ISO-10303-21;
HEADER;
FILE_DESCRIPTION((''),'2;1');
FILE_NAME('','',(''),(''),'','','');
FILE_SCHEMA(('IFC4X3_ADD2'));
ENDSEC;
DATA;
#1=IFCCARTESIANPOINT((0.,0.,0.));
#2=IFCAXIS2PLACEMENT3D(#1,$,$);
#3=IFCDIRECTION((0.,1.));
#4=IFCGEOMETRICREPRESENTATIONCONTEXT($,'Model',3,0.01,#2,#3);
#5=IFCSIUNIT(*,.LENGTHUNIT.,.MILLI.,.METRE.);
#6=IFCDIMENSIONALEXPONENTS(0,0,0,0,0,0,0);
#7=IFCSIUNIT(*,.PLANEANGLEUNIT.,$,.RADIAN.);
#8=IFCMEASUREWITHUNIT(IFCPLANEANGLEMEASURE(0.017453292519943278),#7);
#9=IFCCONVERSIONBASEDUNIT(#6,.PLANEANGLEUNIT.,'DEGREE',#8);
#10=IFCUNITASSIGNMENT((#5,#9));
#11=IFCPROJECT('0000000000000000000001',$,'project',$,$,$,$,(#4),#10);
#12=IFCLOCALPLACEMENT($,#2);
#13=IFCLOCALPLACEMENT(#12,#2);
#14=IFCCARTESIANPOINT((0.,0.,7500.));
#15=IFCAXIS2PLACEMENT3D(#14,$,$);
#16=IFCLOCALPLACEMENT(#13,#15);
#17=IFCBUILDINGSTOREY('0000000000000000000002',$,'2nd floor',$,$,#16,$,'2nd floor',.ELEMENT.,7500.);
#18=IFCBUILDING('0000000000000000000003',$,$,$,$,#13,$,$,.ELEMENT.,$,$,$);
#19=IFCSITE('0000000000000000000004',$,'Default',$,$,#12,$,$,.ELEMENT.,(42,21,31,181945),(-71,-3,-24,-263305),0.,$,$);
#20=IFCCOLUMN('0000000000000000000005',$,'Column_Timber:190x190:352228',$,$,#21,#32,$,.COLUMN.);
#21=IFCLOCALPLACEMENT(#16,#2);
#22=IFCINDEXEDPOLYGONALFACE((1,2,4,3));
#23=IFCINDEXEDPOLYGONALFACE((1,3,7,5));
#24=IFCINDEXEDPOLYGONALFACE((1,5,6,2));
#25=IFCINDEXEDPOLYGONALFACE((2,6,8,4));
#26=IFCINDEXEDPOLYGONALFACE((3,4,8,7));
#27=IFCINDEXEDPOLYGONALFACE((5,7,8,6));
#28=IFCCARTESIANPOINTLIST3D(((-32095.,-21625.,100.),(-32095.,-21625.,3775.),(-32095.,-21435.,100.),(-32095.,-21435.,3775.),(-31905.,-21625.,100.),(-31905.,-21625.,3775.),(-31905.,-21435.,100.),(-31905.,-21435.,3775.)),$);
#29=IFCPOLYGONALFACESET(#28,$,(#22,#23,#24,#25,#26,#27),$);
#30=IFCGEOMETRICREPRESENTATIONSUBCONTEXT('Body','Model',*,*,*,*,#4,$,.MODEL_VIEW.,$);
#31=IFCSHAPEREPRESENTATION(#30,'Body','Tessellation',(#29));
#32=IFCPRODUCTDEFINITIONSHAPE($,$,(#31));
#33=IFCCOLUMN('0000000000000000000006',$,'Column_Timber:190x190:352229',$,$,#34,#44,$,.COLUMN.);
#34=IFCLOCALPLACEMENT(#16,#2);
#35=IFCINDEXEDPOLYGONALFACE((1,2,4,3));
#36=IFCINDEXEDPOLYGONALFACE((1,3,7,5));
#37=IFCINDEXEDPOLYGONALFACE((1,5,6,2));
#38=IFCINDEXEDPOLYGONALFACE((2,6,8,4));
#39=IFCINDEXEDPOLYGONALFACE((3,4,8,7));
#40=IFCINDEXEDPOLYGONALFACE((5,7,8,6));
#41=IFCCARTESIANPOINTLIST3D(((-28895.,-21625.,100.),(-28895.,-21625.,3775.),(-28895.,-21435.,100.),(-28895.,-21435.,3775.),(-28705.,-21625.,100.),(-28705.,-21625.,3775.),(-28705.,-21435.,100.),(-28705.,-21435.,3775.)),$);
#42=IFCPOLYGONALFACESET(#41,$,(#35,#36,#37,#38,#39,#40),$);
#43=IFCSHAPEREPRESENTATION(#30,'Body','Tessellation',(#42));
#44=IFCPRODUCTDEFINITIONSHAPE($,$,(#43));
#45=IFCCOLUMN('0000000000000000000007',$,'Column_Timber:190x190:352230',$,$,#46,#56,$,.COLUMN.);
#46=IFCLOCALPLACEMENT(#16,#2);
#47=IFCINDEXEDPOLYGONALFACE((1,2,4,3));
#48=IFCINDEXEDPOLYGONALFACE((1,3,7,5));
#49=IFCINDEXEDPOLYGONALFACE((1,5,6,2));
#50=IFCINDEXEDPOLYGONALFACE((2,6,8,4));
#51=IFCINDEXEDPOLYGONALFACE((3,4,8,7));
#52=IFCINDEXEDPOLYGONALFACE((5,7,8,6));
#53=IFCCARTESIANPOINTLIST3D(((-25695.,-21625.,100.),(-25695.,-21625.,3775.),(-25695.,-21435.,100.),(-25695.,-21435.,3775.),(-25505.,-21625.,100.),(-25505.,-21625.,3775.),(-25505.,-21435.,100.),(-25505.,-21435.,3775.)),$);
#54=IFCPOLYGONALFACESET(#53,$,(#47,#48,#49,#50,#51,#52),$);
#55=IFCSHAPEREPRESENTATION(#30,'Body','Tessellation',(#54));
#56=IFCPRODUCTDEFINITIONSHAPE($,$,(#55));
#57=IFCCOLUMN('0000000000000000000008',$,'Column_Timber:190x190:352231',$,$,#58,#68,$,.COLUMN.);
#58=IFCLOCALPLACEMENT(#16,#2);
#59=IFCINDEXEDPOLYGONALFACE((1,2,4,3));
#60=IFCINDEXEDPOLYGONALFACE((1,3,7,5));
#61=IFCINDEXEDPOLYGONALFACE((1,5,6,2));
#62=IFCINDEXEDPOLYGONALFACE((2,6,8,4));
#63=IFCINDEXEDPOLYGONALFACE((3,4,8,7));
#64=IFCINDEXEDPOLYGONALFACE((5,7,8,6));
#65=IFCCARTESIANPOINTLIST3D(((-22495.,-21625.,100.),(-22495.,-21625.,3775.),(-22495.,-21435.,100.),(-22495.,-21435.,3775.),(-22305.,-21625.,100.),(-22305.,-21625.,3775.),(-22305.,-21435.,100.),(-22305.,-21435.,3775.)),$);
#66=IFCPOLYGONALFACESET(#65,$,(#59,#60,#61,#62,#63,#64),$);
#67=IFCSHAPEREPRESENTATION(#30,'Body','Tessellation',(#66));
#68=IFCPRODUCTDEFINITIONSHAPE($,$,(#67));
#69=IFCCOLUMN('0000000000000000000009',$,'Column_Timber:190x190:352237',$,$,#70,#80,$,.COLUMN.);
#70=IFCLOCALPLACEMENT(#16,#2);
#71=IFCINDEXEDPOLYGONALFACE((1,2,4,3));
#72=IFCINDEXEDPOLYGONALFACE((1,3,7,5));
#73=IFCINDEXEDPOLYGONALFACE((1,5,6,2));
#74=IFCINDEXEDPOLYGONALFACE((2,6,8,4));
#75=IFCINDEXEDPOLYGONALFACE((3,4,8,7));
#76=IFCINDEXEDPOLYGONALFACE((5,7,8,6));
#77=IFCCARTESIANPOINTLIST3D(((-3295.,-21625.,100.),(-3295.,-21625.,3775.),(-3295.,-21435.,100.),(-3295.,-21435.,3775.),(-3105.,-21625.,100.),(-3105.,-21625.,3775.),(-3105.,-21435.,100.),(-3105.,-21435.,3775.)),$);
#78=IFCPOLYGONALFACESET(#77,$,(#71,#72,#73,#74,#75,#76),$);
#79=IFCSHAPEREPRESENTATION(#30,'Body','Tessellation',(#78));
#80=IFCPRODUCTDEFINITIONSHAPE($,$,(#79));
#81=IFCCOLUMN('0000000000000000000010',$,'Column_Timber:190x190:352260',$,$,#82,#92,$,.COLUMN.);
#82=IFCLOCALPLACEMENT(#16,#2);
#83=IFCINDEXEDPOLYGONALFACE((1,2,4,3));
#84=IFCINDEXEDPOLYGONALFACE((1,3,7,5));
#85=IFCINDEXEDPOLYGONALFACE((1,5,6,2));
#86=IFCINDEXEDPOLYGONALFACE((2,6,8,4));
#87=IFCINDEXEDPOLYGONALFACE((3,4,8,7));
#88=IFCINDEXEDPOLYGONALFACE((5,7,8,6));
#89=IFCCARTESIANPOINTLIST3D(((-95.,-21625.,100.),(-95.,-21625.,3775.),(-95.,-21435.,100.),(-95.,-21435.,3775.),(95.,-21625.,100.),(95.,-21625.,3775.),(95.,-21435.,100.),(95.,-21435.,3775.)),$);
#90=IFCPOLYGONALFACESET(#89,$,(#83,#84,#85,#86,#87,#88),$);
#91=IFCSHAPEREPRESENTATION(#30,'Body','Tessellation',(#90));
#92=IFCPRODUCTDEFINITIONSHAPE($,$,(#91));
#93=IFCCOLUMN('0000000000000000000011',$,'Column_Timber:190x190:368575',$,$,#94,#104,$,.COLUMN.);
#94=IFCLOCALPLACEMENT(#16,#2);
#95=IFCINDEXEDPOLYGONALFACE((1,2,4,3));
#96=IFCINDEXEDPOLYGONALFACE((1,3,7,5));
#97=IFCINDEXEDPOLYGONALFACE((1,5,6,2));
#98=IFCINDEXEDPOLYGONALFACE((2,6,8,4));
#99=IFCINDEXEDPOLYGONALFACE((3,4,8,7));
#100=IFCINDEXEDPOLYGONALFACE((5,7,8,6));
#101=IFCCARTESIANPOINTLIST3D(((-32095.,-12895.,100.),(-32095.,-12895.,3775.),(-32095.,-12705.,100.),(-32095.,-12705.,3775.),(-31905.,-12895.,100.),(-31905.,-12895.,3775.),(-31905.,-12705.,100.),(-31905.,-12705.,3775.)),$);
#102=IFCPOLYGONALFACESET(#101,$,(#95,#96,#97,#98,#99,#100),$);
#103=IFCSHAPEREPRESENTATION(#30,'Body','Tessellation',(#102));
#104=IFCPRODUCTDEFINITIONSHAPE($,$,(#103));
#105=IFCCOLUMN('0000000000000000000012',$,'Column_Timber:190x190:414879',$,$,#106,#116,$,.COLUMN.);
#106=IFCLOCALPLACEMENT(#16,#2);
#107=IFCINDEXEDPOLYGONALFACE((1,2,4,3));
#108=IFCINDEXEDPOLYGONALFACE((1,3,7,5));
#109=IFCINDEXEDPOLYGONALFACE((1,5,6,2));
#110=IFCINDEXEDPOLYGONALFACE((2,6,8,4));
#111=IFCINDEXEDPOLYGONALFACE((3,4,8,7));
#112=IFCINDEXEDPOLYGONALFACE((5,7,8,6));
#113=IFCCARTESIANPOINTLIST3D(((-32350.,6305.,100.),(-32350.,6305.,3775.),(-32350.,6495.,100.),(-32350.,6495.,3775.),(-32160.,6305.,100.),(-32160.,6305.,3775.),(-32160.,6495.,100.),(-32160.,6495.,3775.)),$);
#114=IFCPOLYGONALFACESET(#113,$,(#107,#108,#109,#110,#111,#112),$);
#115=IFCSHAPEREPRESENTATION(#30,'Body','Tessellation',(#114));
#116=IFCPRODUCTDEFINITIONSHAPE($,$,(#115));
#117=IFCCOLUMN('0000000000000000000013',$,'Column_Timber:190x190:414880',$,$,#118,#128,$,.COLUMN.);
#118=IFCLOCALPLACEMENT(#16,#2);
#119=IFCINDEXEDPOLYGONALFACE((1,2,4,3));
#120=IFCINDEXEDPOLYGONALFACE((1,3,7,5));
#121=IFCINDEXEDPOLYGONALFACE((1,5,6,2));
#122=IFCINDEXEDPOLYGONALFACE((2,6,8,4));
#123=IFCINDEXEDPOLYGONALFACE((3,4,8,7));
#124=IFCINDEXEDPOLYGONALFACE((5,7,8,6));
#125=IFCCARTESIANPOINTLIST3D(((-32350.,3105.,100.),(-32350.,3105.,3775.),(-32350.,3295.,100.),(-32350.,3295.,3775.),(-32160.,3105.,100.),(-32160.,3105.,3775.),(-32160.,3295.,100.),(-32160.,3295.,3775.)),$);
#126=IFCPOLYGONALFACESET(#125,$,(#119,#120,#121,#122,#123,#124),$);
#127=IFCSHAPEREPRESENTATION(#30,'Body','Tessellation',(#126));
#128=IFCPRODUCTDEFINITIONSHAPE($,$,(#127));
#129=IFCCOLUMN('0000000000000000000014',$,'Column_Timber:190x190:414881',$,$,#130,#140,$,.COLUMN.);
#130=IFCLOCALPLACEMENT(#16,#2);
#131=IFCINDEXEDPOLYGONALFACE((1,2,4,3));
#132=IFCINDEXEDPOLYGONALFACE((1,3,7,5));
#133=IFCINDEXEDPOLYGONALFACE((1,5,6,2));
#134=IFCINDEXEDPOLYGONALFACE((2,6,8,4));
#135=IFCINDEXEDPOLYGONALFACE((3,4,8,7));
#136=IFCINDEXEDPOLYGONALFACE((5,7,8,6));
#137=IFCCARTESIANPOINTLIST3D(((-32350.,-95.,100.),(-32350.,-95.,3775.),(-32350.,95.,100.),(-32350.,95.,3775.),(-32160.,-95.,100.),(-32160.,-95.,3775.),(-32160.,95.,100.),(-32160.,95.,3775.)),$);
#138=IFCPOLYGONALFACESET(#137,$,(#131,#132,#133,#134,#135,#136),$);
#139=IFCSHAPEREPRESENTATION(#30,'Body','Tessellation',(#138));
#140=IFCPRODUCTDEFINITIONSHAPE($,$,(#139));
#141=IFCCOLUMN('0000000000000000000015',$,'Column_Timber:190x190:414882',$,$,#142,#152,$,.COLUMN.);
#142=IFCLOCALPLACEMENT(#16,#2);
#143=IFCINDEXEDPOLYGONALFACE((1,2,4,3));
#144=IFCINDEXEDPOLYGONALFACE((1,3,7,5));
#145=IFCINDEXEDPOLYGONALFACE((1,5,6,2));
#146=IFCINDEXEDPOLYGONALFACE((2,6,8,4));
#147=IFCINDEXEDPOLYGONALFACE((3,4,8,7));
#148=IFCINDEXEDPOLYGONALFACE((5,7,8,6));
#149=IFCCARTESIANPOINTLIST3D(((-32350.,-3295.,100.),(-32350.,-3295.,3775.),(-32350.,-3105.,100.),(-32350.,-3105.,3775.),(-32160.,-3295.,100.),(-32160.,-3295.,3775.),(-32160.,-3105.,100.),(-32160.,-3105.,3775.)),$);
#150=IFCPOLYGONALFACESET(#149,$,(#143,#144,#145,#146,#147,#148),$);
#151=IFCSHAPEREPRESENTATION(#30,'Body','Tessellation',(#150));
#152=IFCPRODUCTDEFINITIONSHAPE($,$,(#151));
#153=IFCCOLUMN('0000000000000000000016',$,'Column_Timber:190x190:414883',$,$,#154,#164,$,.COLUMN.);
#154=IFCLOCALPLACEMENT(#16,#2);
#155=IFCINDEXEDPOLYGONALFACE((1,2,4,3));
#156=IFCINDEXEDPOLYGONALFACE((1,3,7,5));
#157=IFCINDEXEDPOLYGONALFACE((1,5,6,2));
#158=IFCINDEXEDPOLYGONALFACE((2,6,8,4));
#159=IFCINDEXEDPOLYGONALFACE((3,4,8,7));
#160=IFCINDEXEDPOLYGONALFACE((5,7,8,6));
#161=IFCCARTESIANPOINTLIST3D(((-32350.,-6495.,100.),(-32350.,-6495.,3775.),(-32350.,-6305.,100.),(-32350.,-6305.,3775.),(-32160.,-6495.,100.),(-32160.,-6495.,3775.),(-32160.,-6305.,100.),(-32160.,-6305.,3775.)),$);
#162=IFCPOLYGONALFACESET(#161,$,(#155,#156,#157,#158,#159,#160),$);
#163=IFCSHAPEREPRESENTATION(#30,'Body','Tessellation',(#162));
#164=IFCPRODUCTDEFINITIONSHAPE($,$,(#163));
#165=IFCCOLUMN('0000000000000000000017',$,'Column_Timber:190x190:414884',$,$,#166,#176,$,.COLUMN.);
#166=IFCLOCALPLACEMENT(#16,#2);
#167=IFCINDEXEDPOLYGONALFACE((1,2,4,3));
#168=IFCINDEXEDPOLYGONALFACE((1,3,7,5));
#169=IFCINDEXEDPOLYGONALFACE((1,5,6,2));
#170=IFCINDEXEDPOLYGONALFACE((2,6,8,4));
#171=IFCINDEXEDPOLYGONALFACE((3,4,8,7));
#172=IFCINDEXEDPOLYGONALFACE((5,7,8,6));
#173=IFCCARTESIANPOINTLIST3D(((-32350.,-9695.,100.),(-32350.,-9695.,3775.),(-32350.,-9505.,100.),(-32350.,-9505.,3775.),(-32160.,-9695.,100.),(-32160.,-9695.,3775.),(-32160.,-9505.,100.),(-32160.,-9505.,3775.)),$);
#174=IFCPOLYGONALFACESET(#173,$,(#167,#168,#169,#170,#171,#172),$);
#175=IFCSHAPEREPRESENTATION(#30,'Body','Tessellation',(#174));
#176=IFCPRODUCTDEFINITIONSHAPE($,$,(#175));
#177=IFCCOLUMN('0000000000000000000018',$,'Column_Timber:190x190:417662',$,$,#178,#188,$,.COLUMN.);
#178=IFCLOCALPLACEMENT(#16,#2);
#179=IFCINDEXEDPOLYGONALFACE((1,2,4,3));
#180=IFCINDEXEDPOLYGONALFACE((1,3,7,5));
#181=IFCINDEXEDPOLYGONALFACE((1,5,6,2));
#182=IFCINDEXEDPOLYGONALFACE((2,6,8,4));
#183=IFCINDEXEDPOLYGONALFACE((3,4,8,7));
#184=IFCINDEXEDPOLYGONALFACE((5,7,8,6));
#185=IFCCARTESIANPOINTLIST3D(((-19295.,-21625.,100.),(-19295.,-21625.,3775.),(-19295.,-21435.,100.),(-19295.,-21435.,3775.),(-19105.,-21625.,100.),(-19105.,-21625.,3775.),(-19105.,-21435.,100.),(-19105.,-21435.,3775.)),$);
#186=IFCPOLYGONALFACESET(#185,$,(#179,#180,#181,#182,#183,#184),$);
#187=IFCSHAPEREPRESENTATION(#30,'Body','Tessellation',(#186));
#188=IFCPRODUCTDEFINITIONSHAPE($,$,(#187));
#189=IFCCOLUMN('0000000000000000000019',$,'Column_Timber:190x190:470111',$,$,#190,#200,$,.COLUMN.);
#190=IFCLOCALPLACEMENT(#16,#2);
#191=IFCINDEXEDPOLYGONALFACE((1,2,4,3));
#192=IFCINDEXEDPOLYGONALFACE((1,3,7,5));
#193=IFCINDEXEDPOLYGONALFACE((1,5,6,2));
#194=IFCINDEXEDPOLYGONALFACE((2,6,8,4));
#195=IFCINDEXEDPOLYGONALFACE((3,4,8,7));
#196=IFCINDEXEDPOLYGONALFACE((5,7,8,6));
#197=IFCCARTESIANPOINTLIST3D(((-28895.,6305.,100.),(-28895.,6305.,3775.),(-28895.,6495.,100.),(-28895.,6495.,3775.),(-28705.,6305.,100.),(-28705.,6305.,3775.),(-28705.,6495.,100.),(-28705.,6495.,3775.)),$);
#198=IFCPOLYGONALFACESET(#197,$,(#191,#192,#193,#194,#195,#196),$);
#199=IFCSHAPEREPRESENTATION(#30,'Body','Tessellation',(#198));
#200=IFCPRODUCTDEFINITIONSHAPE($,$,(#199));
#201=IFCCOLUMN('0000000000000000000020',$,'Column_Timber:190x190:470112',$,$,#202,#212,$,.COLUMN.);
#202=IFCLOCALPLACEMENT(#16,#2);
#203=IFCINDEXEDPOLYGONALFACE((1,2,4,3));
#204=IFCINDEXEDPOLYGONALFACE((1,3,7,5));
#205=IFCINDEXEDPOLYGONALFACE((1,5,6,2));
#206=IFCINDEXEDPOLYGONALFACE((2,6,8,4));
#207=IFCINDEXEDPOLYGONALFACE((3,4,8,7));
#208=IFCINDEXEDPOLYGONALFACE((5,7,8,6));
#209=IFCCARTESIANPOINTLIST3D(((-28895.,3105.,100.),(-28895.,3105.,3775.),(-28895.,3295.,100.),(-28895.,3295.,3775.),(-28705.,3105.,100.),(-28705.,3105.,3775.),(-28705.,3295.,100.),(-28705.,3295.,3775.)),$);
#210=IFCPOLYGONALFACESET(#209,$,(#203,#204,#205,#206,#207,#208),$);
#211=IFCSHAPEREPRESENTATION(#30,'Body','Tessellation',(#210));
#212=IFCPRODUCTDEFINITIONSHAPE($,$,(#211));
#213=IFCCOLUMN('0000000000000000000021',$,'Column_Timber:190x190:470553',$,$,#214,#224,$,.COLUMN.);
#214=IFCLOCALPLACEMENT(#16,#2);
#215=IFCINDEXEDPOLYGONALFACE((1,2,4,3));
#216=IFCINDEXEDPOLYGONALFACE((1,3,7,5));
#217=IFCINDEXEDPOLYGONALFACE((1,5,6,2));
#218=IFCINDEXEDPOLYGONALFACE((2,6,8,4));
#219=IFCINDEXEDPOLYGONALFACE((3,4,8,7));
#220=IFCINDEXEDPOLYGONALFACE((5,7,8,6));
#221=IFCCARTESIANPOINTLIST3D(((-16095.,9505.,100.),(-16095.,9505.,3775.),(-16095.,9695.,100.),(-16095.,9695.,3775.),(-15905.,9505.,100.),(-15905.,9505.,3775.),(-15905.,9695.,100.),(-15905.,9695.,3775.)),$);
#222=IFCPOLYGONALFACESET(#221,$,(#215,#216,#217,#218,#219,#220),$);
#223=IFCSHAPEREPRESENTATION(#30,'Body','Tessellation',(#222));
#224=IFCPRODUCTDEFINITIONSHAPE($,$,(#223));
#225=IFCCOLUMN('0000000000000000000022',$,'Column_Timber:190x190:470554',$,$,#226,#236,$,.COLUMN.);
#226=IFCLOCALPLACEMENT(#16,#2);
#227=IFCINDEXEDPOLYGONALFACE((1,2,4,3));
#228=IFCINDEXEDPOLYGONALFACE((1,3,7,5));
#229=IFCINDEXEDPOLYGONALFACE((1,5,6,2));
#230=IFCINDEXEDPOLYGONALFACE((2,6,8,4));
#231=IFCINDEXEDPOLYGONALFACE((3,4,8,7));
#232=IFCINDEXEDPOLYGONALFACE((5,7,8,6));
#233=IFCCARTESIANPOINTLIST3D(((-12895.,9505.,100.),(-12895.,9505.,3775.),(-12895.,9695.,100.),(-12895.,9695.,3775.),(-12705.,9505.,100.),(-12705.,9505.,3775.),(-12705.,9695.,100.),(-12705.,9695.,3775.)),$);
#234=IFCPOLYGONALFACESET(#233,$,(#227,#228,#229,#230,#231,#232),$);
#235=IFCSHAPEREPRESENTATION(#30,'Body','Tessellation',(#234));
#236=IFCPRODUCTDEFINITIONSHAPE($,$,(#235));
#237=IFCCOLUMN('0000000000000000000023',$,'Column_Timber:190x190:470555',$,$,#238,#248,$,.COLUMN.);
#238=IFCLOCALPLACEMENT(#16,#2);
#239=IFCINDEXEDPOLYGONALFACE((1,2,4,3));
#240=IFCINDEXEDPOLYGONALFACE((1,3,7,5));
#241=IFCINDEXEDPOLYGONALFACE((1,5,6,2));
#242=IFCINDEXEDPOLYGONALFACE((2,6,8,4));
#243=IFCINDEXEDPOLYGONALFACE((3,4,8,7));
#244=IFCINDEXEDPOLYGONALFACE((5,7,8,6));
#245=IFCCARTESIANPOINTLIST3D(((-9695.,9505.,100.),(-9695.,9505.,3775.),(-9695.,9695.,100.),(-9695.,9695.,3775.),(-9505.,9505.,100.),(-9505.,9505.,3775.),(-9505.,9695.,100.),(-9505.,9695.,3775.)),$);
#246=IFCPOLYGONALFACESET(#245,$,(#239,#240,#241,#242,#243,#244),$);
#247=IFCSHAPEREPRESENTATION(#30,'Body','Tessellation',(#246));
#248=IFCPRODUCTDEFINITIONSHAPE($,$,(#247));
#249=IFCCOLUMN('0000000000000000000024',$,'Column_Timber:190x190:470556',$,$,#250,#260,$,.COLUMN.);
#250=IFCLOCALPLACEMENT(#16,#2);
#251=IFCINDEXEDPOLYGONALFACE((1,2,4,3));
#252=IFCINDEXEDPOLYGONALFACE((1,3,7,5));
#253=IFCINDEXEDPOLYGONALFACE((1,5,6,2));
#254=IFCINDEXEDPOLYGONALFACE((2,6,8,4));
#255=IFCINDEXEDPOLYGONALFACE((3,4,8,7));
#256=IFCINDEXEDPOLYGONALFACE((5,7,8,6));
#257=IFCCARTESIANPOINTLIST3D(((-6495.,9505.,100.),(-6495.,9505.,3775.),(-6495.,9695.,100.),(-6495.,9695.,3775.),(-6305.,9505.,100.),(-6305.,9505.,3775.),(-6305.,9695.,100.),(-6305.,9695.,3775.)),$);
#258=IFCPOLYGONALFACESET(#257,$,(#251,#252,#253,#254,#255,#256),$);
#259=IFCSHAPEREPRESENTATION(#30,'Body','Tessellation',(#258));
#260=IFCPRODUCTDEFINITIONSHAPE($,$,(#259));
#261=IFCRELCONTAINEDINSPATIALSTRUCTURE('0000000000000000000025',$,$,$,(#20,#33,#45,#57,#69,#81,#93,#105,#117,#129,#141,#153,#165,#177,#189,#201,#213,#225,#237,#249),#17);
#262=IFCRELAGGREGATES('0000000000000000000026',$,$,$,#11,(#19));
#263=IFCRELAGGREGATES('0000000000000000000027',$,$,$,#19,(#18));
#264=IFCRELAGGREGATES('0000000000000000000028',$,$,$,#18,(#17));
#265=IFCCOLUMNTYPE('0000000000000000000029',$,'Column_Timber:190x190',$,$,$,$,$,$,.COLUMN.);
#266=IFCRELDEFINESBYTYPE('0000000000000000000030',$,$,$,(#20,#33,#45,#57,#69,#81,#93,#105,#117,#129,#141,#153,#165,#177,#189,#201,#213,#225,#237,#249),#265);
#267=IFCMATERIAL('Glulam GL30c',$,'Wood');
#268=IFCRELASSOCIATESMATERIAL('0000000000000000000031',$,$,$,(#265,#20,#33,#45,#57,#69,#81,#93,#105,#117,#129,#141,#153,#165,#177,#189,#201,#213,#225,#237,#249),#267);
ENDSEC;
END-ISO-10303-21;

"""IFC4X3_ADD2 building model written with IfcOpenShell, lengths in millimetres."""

from ifc_helpers import new_model, entity, si_unit, converted_unit, direction, frame, origin, origin_2d_with_axis, place, context, subcontext, project, spatial, rectangle, extrude, source, transform, mapped, material, material_profile, profile_set, profile_usage, type_object, type_shapes, element, save


model = new_model("IFC4X3_ADD2")

# Units and contexts
model_context = context("Model", 3, precision=0.01, world=origin(), true_north=direction((0.0, 1.0)))
body_context = subcontext(model_context, "Body", "Model", "MODEL_VIEW")
ifc_project = project(units=[si_unit("LENGTHUNIT", "METRE", prefix="MILLI"), converted_unit("PLANEANGLEUNIT", "DEGREE", entity("IfcPlaneAngleMeasure", 0.017453292519943278), si_unit("PLANEANGLEUNIT", "RADIAN"), dimensions=[0, 0, 0, 0, 0, 0, 0])], contexts=[model_context])

# Site, building, storey
site_placement = place(None, origin())
site = spatial("IfcSite", under=ifc_project, at=site_placement, Name="Default", CompositionType="ELEMENT", RefLatitude=(42, 21, 31, 181945), RefLongitude=(-71, -3, -24, -263305), RefElevation=0.0)
building_placement = place(site_placement, origin())
building = spatial("IfcBuilding", under=site, at=building_placement, CompositionType="ELEMENT")
storey_placement = place(building_placement, frame((0.0, 0.0, 7500.0)))
storey = spatial("IfcBuildingStorey", under=building, at=storey_placement, Name="2nd floor", LongName="2nd floor", CompositionType="ELEMENT", Elevation=7500.0)

# Columns
ifc_material_1 = material(Name="Glulam GL30c", Category="Wood")
ifc_material_profile_1 = material_profile(ifc_material_1, rectangle(XDim=190.0, YDim=190.0, at=origin_2d_with_axis()), Name="190x190")
ifc_profile_set_1 = profile_set([ifc_material_profile_1], Name="190x190")
ifc_profile_usage_1 = profile_usage(ifc_profile_set_1)
column_type = type_object("IfcColumnType", Name="Column_Timber:190x190", PredefinedType="COLUMN", material=ifc_profile_set_1)
shared_shape_1 = source(origin(), body_context, "Body", "SweptSolid", [
    extrude(rectangle(XDim=190.0, YDim=190.0, at=origin_2d_with_axis()), frame((0.0, 0.0, 7600.0), z_axis=(0.0, 0.0, 1.0), x_axis=(-1.0, 0.0, 0.0)), (0.0, 0.0, 1.0), 3675.0),
])
type_shapes(column_type, [shared_shape_1])
for number, where, name in (
    (1, (-32000.0, -21530.0, -7500.0), "Column_Timber:190x190:352228"),
    (2, (-28800.0, -21530.0, -7500.0), "Column_Timber:190x190:352229"),
    (3, (-25600.0, -21530.0, -7500.0), "Column_Timber:190x190:352230"),
    (4, (-22400.0, -21530.0, -7500.0), "Column_Timber:190x190:352231"),
    (5, (-3200.0, -21530.0, -7500.0), "Column_Timber:190x190:352237"),
    (6, (0.0, -21530.0, -7500.0), "Column_Timber:190x190:352260"),
    (7, (-32000.0, -12800.0, -7500.0), "Column_Timber:190x190:368575"),
    (8, (-32255.0, 6400.0, -7500.0), "Column_Timber:190x190:414879"),
    (9, (-32255.0, 3200.0, -7500.0), "Column_Timber:190x190:414880"),
    (10, (-32255.0, 0.0, -7500.0), "Column_Timber:190x190:414881"),
    (11, (-32255.0, -3200.0, -7500.0), "Column_Timber:190x190:414882"),
    (12, (-32255.0, -6400.0, -7500.0), "Column_Timber:190x190:414883"),
    (13, (-32255.0, -9600.0, -7500.0), "Column_Timber:190x190:414884"),
    (14, (-19200.0, -21530.0, -7500.0), "Column_Timber:190x190:417662"),
    (15, (-28800.0, 6400.0, -7500.0), "Column_Timber:190x190:470111"),
    (16, (-28800.0, 3200.0, -7500.0), "Column_Timber:190x190:470112"),
    (17, (-16000.0, 9600.0, -7500.0), "Column_Timber:190x190:470553"),
    (18, (-12800.0, 9600.0, -7500.0), "Column_Timber:190x190:470554"),
    (19, (-9600.0, 9600.0, -7500.0), "Column_Timber:190x190:470555"),
    (20, (-6400.0, 9600.0, -7500.0), "Column_Timber:190x190:470556"),
):
    element("IfcColumn", number, at=place(storey_placement, frame(where)), inside=storey, type_object=column_type, material=ifc_profile_usage_1, Name=name, PredefinedType="COLUMN", context=body_context, shape_type="MappedRepresentation", body=[
        mapped(shared_shape_1, transform((0.0, 0.0, 0.0), scale=1.0)),
    ])

save(model, "model.ifc")
